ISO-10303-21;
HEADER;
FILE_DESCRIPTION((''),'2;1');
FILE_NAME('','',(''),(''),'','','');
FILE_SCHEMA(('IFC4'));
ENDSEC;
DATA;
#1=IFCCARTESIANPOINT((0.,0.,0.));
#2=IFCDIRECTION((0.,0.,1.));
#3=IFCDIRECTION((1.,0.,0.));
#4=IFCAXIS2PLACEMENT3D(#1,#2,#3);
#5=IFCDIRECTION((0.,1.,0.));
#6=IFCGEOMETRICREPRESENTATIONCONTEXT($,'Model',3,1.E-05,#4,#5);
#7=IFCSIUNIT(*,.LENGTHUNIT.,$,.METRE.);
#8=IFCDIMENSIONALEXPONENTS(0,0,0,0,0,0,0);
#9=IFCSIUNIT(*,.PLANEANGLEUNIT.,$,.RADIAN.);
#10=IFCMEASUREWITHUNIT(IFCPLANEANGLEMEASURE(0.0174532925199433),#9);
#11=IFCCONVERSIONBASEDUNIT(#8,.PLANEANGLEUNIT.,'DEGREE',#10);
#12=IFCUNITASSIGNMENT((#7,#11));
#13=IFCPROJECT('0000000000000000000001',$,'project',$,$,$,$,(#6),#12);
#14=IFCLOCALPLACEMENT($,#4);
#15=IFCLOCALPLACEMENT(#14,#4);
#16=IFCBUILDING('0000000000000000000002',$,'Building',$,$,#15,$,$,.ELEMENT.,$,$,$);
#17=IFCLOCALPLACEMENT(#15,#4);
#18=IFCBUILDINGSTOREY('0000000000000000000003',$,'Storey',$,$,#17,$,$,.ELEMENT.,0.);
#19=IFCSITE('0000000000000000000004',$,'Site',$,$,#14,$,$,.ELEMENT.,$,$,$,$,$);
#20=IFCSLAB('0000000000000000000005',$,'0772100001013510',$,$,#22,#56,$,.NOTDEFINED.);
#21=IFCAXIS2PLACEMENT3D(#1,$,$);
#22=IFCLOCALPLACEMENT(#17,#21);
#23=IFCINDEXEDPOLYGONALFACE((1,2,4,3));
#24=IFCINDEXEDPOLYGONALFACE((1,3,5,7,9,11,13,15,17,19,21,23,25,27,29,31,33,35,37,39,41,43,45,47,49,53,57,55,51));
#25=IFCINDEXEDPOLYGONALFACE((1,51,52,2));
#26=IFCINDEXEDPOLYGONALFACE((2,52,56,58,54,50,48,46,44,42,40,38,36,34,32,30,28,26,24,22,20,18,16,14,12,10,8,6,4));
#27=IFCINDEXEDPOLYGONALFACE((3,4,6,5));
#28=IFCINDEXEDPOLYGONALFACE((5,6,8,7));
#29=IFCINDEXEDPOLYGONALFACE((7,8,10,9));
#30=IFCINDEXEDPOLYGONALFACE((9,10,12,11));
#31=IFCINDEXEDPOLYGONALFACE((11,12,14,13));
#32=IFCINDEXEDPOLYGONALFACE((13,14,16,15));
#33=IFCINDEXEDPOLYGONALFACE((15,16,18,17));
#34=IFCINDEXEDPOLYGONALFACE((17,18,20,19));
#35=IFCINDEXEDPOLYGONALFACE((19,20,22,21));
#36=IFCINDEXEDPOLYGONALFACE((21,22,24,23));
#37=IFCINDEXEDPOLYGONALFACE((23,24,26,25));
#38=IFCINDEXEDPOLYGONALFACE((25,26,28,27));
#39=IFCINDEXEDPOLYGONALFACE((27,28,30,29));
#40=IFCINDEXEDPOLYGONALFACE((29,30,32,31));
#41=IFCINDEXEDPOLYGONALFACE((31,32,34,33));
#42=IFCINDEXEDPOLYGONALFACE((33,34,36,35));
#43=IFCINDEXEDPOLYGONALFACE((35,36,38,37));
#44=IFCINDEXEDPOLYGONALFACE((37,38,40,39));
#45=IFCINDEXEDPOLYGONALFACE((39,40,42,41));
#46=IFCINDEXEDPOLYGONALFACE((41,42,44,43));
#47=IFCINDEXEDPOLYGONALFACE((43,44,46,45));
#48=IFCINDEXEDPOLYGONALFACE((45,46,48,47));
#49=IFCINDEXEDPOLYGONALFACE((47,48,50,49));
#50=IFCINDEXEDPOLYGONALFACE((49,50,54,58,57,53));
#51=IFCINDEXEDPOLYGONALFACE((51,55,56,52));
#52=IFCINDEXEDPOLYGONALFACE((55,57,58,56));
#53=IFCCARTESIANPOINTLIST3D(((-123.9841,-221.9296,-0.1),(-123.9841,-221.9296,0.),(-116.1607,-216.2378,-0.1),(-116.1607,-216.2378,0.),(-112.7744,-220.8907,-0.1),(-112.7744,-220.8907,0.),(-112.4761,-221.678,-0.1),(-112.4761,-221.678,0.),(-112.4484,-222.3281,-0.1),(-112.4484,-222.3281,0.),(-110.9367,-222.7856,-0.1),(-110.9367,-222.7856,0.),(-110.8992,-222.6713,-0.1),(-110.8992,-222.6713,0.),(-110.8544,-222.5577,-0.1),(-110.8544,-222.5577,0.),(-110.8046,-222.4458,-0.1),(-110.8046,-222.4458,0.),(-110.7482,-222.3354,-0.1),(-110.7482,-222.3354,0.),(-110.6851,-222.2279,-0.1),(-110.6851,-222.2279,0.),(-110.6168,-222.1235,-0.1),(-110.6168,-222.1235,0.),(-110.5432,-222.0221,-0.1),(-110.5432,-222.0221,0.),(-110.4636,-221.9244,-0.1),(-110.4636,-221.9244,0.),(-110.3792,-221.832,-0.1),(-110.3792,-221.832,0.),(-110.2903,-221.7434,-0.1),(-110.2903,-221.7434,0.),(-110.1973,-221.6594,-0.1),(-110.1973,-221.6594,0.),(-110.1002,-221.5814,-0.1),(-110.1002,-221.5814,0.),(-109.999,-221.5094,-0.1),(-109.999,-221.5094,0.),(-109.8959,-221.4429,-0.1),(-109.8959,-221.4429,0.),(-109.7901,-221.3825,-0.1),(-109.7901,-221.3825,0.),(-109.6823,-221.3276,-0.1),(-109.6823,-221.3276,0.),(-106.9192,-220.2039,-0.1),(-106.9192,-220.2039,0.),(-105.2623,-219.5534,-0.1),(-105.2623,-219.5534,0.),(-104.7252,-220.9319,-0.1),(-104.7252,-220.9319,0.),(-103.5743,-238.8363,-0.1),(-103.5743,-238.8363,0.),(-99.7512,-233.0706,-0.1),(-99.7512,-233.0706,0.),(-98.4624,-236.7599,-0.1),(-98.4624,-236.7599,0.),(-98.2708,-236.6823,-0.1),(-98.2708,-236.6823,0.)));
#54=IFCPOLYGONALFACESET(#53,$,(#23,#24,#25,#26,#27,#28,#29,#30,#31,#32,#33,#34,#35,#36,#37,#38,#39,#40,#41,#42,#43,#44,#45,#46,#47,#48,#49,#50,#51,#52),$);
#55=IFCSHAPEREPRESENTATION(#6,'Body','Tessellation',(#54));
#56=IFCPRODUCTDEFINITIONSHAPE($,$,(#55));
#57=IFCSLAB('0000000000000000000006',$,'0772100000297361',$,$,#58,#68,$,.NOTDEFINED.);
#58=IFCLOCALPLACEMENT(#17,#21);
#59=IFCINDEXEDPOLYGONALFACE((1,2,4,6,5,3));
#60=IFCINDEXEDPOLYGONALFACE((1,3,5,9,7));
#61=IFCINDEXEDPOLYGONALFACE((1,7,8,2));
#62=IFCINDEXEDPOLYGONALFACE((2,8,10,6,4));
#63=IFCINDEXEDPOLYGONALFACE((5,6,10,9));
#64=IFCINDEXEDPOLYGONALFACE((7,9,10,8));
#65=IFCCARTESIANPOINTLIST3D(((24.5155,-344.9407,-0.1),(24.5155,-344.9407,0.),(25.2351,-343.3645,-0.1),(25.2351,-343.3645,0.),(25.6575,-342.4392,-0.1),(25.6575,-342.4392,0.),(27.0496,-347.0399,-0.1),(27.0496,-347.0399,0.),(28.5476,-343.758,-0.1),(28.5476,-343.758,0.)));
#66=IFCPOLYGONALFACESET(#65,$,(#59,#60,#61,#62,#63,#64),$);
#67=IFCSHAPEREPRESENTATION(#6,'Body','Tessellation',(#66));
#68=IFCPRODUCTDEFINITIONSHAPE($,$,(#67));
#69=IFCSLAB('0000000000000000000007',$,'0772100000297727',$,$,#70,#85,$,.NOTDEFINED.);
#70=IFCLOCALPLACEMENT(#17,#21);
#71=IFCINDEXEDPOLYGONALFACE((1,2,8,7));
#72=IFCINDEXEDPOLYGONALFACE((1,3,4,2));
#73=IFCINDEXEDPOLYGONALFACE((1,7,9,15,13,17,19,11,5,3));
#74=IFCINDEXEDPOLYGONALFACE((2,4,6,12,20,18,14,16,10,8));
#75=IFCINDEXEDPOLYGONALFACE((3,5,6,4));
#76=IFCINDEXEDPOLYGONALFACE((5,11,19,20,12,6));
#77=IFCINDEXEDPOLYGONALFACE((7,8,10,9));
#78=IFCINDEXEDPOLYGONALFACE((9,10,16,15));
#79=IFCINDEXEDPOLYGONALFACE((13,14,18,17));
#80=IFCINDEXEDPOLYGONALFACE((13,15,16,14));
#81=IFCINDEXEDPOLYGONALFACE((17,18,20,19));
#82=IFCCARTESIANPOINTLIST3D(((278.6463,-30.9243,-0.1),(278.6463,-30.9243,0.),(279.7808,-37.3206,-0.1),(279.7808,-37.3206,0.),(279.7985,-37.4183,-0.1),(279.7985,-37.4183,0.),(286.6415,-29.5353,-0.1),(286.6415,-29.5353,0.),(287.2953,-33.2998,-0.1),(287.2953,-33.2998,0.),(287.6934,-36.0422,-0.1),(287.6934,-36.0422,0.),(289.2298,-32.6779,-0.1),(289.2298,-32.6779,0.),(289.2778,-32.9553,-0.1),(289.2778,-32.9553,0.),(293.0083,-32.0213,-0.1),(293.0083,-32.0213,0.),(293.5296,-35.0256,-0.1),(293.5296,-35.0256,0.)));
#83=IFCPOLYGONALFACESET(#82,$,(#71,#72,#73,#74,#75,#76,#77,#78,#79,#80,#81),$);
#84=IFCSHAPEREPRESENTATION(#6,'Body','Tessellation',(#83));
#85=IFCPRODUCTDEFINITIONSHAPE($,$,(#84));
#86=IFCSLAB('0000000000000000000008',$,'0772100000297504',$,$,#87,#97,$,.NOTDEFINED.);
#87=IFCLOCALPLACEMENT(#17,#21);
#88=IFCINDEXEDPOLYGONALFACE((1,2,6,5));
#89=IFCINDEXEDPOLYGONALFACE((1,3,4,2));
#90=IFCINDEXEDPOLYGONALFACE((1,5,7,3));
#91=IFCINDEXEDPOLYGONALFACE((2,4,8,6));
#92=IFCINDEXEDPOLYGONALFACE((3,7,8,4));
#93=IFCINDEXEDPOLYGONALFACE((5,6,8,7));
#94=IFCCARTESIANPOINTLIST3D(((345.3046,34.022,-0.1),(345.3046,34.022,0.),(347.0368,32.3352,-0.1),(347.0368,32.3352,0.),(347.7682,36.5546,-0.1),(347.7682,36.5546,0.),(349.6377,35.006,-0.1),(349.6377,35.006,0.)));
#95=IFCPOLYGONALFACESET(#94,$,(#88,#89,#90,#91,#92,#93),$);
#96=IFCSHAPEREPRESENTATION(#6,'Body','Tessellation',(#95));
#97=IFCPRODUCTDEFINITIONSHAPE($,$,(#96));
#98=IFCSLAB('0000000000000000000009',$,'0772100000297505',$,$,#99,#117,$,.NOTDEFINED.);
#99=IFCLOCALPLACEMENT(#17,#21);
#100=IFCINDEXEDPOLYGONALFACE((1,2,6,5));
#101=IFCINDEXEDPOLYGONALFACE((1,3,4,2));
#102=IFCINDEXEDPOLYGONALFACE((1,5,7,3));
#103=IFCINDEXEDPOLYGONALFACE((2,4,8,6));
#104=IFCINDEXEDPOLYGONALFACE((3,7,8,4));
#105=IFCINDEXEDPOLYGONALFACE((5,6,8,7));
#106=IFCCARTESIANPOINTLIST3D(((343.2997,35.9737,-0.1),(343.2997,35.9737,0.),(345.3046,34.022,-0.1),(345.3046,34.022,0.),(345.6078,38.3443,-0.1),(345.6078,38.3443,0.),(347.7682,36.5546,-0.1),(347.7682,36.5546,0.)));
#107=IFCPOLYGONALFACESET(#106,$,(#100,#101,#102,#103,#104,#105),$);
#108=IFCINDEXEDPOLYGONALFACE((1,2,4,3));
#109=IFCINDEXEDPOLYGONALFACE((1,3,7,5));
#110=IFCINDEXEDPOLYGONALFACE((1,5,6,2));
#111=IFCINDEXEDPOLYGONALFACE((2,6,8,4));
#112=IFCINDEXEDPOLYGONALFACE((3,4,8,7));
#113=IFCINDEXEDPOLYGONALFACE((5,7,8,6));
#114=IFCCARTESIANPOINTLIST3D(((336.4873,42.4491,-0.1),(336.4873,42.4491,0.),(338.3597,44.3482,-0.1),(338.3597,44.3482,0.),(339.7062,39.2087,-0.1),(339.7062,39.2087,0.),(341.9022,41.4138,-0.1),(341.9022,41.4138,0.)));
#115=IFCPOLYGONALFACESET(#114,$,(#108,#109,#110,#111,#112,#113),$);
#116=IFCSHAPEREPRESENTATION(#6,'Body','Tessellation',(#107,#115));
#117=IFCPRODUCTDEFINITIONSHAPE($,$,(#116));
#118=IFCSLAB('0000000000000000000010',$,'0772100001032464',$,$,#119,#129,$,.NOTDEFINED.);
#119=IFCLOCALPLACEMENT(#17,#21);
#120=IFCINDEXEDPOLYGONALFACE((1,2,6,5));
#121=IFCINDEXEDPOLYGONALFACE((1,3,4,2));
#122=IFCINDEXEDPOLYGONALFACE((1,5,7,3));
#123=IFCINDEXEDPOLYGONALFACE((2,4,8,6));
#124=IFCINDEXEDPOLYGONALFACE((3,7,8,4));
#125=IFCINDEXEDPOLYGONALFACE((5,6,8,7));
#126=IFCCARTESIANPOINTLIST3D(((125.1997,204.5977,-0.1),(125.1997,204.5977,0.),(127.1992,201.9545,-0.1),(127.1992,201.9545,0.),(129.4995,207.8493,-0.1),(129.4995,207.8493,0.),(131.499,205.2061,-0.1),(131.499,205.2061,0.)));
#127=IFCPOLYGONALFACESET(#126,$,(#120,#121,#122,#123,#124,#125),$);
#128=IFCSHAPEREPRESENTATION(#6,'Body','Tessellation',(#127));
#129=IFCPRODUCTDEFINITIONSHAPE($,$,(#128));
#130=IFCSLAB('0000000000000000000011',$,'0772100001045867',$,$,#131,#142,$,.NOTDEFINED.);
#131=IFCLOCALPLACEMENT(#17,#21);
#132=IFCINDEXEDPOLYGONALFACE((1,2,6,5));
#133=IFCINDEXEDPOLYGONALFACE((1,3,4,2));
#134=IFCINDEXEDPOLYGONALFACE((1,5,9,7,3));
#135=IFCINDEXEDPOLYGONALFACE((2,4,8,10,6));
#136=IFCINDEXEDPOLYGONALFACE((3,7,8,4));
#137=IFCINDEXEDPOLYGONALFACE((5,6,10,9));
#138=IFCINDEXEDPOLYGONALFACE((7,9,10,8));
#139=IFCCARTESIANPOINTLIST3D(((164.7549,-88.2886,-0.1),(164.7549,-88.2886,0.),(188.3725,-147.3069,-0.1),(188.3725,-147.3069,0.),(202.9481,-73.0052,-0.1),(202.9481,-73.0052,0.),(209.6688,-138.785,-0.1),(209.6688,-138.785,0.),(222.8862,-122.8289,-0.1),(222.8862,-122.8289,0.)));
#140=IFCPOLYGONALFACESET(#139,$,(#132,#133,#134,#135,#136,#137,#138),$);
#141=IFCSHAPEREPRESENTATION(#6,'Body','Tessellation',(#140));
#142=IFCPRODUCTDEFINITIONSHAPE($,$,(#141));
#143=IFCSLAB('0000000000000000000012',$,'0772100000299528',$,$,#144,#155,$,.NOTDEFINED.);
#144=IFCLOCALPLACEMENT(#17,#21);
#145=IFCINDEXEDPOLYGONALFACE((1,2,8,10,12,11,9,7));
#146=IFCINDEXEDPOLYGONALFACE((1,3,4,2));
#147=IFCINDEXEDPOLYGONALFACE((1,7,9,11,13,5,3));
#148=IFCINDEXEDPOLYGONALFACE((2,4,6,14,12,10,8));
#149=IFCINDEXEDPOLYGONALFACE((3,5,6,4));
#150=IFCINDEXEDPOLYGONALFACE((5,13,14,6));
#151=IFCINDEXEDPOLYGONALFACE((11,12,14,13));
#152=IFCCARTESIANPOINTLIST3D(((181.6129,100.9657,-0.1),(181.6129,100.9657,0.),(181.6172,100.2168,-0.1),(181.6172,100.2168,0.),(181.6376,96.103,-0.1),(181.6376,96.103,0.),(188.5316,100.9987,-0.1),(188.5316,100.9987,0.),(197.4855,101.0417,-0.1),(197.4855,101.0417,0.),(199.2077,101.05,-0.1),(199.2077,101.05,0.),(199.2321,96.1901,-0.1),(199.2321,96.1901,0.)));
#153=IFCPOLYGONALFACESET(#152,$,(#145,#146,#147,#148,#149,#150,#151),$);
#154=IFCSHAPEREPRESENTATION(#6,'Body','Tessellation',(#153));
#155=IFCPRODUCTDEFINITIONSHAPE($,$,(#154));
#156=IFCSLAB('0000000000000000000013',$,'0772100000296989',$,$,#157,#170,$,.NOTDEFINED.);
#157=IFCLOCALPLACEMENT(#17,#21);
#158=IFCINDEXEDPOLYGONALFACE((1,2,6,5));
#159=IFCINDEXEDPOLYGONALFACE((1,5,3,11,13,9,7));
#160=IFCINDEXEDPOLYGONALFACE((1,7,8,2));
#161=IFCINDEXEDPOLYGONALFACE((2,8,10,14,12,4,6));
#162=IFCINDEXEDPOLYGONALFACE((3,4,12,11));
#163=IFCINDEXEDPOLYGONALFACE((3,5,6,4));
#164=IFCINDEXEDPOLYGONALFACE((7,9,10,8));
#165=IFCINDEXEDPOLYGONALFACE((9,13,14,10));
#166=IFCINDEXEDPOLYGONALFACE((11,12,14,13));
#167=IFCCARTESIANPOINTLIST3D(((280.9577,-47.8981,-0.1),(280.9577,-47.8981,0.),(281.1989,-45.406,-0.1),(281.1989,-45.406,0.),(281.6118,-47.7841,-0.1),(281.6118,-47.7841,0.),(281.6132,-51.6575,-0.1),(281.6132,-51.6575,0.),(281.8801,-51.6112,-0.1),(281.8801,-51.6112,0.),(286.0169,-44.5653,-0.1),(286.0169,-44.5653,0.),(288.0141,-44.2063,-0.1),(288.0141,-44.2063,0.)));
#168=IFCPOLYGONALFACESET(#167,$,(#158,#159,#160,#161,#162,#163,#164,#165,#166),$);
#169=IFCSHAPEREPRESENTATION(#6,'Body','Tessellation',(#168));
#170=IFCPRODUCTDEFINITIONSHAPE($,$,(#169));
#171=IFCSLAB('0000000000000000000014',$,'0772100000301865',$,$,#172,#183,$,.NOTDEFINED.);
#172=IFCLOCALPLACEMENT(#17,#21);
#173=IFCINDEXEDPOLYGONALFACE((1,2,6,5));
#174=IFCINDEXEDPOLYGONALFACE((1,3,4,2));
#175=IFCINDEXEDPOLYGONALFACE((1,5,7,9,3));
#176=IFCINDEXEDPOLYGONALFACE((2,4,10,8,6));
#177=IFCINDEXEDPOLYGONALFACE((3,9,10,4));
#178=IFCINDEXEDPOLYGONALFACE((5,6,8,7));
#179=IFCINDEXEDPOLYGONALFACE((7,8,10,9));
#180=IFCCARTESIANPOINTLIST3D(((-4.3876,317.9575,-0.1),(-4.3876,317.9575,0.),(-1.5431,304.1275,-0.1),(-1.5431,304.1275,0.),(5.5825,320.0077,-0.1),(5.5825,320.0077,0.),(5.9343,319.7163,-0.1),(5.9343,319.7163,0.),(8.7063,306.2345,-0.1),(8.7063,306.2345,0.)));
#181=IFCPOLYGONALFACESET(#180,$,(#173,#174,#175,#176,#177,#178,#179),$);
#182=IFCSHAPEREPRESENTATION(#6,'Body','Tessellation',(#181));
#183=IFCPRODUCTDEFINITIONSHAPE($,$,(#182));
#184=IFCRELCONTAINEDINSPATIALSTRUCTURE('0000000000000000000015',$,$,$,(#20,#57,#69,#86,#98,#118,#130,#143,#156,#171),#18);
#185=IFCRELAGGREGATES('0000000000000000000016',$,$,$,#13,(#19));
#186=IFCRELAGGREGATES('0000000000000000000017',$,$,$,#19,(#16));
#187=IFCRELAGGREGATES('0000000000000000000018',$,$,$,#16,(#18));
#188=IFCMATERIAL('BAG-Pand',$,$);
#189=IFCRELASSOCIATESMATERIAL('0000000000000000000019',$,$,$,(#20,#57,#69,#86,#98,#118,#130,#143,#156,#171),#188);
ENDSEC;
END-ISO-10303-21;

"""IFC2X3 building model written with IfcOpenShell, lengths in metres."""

from ifc_helpers import new_model, entity, si_unit, converted_unit, direction, frame, origin_with_axes, place, context, project, spatial, polyline, outline, extrude, material, element, save


model = new_model("IFC2X3")

# Units and contexts
model_context = context("Model", 3, precision=1e-05, world=origin_with_axes(), true_north=direction((0.0, 1.0, 0.0)))
ifc_project = project(units=[si_unit("LENGTHUNIT", "METRE"), converted_unit("PLANEANGLEUNIT", "DEGREE", entity("IfcPlaneAngleMeasure", 0.0174532925199433), si_unit("PLANEANGLEUNIT", "RADIAN"), dimensions=[0, 0, 0, 0, 0, 0, 0])], contexts=[model_context])

# Site, building, storey
site_placement = place(None, origin_with_axes())
site = spatial("IfcSite", under=ifc_project, at=site_placement, Name="Site", CompositionType="ELEMENT")
building_placement = place(site_placement, origin_with_axes())
building = spatial("IfcBuilding", under=site, at=building_placement, Name="Building", CompositionType="ELEMENT")
storey_placement = place(building_placement, origin_with_axes())
storey = spatial("IfcBuildingStorey", under=building, at=storey_placement, Name="Storey", CompositionType="ELEMENT", Elevation=0.0)

# Slabs
ifc_material = material(Name="BAG-Pand")
slab_1_placement = place(storey_placement, frame((0.0, 0.0, -0.1), z_axis=(0.0, 0.0, 1.0), x_axis=(1.0, 0.0, 0.0)))
element("IfcSlab", 1, at=slab_1_placement, inside=storey, material=ifc_material, Name="0772100001013510", PredefinedType="NOTDEFINED", context=model_context, shape_type="SweptSolid", body=[
    extrude(outline(polyline([(-116.1607, -216.2378), (-112.7744, -220.8907), (-112.4761, -221.678), (-112.4484, -222.3281), (-110.9367, -222.7856), (-110.8992, -222.6713), (-110.8544, -222.5577), (-110.8046, -222.4458), (-110.7482, -222.3354), (-110.6851, -222.2279), (-110.6168, -222.1235), (-110.5432, -222.0221), (-110.4636, -221.9244), (-110.3792, -221.832), (-110.2903, -221.7434), (-110.1973, -221.6594), (-110.1002, -221.5814), (-109.999, -221.5094), (-109.8959, -221.4429), (-109.7901, -221.3825), (-109.6823, -221.3276), (-106.9192, -220.2039), (-105.2623, -219.5534), (-104.7252, -220.9319), (-99.7512, -233.0706), (-98.2708, -236.6823), (-98.4624, -236.7599), (-103.5743, -238.8363), (-123.9841, -221.9296), (-116.1607, -216.2378)])), origin_with_axes(), (0.0, 0.0, 1.0), 0.1),
])
slab_2_placement = place(storey_placement, frame((0.0, 0.0, -0.1), z_axis=(0.0, 0.0, 1.0), x_axis=(1.0, 0.0, 0.0)))
element("IfcSlab", 2, at=slab_2_placement, inside=storey, material=ifc_material, Name="0772100000297361", PredefinedType="NOTDEFINED", context=model_context, shape_type="SweptSolid", body=[
    extrude(outline(polyline([(25.2351, -343.3645), (25.6575, -342.4392), (28.5476, -343.758), (27.0496, -347.0399), (24.5155, -344.9407), (25.2351, -343.3645)])), origin_with_axes(), (0.0, 0.0, 1.0), 0.1),
])
slab_3_placement = place(storey_placement, frame((0.0, 0.0, -0.1), z_axis=(0.0, 0.0, 1.0), x_axis=(1.0, 0.0, 0.0)))
element("IfcSlab", 3, at=slab_3_placement, inside=storey, material=ifc_material, Name="0772100000297727", PredefinedType="NOTDEFINED", context=model_context, shape_type="SweptSolid", body=[
    extrude(outline(polyline([(279.7808, -37.3206), (278.6463, -30.9243), (286.6415, -29.5353), (287.2953, -33.2998), (289.2778, -32.9553), (289.2298, -32.6779), (293.0083, -32.0213), (293.5296, -35.0256), (287.6934, -36.0422), (279.7985, -37.4183), (279.7808, -37.3206)])), origin_with_axes(), (0.0, 0.0, 1.0), 0.1),
])
slab_4_placement = place(storey_placement, frame((0.0, 0.0, -0.1), z_axis=(0.0, 0.0, 1.0), x_axis=(1.0, 0.0, 0.0)))
element("IfcSlab", 4, at=slab_4_placement, inside=storey, material=ifc_material, Name="0772100000297504", PredefinedType="NOTDEFINED", context=model_context, shape_type="SweptSolid", body=[
    extrude(outline(polyline([(347.0368, 32.3352), (345.3046, 34.022), (347.7682, 36.5546), (349.6377, 35.006), (347.0368, 32.3352)])), origin_with_axes(), (0.0, 0.0, 1.0), 0.1),
])
slab_5_placement = place(storey_placement, frame((0.0, 0.0, -0.1), z_axis=(0.0, 0.0, 1.0), x_axis=(1.0, 0.0, 0.0)))
element("IfcSlab", 5, at=slab_5_placement, inside=storey, material=ifc_material, Name="0772100000297505", PredefinedType="NOTDEFINED", context=model_context, shape_type="SweptSolid", body=[
    extrude(outline(polyline([(345.3046, 34.022), (343.2997, 35.9737), (345.6078, 38.3443), (347.7682, 36.5546), (345.3046, 34.022)])), origin_with_axes(), (0.0, 0.0, 1.0), 0.1),
    extrude(outline(polyline([(339.7062, 39.2087), (336.4873, 42.4491), (338.3597, 44.3482), (341.9022, 41.4138), (339.7062, 39.2087)])), origin_with_axes(), (0.0, 0.0, 1.0), 0.1),
])
slab_6_placement = place(storey_placement, frame((0.0, 0.0, -0.1), z_axis=(0.0, 0.0, 1.0), x_axis=(1.0, 0.0, 0.0)))
element("IfcSlab", 6, at=slab_6_placement, inside=storey, material=ifc_material, Name="0772100001032464", PredefinedType="NOTDEFINED", context=model_context, shape_type="SweptSolid", body=[
    extrude(outline(polyline([(125.1997, 204.5977), (129.4995, 207.8493), (131.499, 205.2061), (127.1992, 201.9545), (125.1997, 204.5977)])), origin_with_axes(), (0.0, 0.0, 1.0), 0.1),
])
slab_7_placement = place(storey_placement, frame((0.0, 0.0, -0.1), z_axis=(0.0, 0.0, 1.0), x_axis=(1.0, 0.0, 0.0)))
element("IfcSlab", 7, at=slab_7_placement, inside=storey, material=ifc_material, Name="0772100001045867", PredefinedType="NOTDEFINED", context=model_context, shape_type="SweptSolid", body=[
    extrude(outline(polyline([(188.3725, -147.3069), (164.7549, -88.2886), (202.9481, -73.0052), (222.8862, -122.8289), (209.6688, -138.785), (188.3725, -147.3069)])), origin_with_axes(), (0.0, 0.0, 1.0), 0.1),
])
slab_8_placement = place(storey_placement, frame((0.0, 0.0, -0.1), z_axis=(0.0, 0.0, 1.0), x_axis=(1.0, 0.0, 0.0)))
element("IfcSlab", 8, at=slab_8_placement, inside=storey, material=ifc_material, Name="0772100000299528", PredefinedType="NOTDEFINED", context=model_context, shape_type="SweptSolid", body=[
    extrude(outline(polyline([(181.6172, 100.2168), (181.6129, 100.9657), (188.5316, 100.9987), (197.4855, 101.0417), (199.2077, 101.05), (199.2321, 96.1901), (181.6376, 96.103), (181.6172, 100.2168)])), origin_with_axes(), (0.0, 0.0, 1.0), 0.1),
])
slab_9_placement = place(storey_placement, frame((0.0, 0.0, -0.1), z_axis=(0.0, 0.0, 1.0), x_axis=(1.0, 0.0, 0.0)))
element("IfcSlab", 9, at=slab_9_placement, inside=storey, material=ifc_material, Name="0772100000296989", PredefinedType="NOTDEFINED", context=model_context, shape_type="SweptSolid", body=[
    extrude(outline(polyline([(281.6132, -51.6575), (280.9577, -47.8981), (281.6118, -47.7841), (281.1989, -45.406), (286.0169, -44.5653), (288.0141, -44.2063), (281.8801, -51.6112), (281.6132, -51.6575)])), origin_with_axes(), (0.0, 0.0, 1.0), 0.1),
])
slab_10_placement = place(storey_placement, frame((0.0, 0.0, -0.1), z_axis=(0.0, 0.0, 1.0), x_axis=(1.0, 0.0, 0.0)))
element("IfcSlab", 10, at=slab_10_placement, inside=storey, material=ifc_material, Name="0772100000301865", PredefinedType="NOTDEFINED", context=model_context, shape_type="SweptSolid", body=[
    extrude(outline(polyline([(8.7063, 306.2345), (-1.5431, 304.1275), (-4.3876, 317.9575), (5.5825, 320.0077), (5.9343, 319.7163), (8.7063, 306.2345)])), origin_with_axes(), (0.0, 0.0, 1.0), 0.1),
])

save(model, "model.ifc")
